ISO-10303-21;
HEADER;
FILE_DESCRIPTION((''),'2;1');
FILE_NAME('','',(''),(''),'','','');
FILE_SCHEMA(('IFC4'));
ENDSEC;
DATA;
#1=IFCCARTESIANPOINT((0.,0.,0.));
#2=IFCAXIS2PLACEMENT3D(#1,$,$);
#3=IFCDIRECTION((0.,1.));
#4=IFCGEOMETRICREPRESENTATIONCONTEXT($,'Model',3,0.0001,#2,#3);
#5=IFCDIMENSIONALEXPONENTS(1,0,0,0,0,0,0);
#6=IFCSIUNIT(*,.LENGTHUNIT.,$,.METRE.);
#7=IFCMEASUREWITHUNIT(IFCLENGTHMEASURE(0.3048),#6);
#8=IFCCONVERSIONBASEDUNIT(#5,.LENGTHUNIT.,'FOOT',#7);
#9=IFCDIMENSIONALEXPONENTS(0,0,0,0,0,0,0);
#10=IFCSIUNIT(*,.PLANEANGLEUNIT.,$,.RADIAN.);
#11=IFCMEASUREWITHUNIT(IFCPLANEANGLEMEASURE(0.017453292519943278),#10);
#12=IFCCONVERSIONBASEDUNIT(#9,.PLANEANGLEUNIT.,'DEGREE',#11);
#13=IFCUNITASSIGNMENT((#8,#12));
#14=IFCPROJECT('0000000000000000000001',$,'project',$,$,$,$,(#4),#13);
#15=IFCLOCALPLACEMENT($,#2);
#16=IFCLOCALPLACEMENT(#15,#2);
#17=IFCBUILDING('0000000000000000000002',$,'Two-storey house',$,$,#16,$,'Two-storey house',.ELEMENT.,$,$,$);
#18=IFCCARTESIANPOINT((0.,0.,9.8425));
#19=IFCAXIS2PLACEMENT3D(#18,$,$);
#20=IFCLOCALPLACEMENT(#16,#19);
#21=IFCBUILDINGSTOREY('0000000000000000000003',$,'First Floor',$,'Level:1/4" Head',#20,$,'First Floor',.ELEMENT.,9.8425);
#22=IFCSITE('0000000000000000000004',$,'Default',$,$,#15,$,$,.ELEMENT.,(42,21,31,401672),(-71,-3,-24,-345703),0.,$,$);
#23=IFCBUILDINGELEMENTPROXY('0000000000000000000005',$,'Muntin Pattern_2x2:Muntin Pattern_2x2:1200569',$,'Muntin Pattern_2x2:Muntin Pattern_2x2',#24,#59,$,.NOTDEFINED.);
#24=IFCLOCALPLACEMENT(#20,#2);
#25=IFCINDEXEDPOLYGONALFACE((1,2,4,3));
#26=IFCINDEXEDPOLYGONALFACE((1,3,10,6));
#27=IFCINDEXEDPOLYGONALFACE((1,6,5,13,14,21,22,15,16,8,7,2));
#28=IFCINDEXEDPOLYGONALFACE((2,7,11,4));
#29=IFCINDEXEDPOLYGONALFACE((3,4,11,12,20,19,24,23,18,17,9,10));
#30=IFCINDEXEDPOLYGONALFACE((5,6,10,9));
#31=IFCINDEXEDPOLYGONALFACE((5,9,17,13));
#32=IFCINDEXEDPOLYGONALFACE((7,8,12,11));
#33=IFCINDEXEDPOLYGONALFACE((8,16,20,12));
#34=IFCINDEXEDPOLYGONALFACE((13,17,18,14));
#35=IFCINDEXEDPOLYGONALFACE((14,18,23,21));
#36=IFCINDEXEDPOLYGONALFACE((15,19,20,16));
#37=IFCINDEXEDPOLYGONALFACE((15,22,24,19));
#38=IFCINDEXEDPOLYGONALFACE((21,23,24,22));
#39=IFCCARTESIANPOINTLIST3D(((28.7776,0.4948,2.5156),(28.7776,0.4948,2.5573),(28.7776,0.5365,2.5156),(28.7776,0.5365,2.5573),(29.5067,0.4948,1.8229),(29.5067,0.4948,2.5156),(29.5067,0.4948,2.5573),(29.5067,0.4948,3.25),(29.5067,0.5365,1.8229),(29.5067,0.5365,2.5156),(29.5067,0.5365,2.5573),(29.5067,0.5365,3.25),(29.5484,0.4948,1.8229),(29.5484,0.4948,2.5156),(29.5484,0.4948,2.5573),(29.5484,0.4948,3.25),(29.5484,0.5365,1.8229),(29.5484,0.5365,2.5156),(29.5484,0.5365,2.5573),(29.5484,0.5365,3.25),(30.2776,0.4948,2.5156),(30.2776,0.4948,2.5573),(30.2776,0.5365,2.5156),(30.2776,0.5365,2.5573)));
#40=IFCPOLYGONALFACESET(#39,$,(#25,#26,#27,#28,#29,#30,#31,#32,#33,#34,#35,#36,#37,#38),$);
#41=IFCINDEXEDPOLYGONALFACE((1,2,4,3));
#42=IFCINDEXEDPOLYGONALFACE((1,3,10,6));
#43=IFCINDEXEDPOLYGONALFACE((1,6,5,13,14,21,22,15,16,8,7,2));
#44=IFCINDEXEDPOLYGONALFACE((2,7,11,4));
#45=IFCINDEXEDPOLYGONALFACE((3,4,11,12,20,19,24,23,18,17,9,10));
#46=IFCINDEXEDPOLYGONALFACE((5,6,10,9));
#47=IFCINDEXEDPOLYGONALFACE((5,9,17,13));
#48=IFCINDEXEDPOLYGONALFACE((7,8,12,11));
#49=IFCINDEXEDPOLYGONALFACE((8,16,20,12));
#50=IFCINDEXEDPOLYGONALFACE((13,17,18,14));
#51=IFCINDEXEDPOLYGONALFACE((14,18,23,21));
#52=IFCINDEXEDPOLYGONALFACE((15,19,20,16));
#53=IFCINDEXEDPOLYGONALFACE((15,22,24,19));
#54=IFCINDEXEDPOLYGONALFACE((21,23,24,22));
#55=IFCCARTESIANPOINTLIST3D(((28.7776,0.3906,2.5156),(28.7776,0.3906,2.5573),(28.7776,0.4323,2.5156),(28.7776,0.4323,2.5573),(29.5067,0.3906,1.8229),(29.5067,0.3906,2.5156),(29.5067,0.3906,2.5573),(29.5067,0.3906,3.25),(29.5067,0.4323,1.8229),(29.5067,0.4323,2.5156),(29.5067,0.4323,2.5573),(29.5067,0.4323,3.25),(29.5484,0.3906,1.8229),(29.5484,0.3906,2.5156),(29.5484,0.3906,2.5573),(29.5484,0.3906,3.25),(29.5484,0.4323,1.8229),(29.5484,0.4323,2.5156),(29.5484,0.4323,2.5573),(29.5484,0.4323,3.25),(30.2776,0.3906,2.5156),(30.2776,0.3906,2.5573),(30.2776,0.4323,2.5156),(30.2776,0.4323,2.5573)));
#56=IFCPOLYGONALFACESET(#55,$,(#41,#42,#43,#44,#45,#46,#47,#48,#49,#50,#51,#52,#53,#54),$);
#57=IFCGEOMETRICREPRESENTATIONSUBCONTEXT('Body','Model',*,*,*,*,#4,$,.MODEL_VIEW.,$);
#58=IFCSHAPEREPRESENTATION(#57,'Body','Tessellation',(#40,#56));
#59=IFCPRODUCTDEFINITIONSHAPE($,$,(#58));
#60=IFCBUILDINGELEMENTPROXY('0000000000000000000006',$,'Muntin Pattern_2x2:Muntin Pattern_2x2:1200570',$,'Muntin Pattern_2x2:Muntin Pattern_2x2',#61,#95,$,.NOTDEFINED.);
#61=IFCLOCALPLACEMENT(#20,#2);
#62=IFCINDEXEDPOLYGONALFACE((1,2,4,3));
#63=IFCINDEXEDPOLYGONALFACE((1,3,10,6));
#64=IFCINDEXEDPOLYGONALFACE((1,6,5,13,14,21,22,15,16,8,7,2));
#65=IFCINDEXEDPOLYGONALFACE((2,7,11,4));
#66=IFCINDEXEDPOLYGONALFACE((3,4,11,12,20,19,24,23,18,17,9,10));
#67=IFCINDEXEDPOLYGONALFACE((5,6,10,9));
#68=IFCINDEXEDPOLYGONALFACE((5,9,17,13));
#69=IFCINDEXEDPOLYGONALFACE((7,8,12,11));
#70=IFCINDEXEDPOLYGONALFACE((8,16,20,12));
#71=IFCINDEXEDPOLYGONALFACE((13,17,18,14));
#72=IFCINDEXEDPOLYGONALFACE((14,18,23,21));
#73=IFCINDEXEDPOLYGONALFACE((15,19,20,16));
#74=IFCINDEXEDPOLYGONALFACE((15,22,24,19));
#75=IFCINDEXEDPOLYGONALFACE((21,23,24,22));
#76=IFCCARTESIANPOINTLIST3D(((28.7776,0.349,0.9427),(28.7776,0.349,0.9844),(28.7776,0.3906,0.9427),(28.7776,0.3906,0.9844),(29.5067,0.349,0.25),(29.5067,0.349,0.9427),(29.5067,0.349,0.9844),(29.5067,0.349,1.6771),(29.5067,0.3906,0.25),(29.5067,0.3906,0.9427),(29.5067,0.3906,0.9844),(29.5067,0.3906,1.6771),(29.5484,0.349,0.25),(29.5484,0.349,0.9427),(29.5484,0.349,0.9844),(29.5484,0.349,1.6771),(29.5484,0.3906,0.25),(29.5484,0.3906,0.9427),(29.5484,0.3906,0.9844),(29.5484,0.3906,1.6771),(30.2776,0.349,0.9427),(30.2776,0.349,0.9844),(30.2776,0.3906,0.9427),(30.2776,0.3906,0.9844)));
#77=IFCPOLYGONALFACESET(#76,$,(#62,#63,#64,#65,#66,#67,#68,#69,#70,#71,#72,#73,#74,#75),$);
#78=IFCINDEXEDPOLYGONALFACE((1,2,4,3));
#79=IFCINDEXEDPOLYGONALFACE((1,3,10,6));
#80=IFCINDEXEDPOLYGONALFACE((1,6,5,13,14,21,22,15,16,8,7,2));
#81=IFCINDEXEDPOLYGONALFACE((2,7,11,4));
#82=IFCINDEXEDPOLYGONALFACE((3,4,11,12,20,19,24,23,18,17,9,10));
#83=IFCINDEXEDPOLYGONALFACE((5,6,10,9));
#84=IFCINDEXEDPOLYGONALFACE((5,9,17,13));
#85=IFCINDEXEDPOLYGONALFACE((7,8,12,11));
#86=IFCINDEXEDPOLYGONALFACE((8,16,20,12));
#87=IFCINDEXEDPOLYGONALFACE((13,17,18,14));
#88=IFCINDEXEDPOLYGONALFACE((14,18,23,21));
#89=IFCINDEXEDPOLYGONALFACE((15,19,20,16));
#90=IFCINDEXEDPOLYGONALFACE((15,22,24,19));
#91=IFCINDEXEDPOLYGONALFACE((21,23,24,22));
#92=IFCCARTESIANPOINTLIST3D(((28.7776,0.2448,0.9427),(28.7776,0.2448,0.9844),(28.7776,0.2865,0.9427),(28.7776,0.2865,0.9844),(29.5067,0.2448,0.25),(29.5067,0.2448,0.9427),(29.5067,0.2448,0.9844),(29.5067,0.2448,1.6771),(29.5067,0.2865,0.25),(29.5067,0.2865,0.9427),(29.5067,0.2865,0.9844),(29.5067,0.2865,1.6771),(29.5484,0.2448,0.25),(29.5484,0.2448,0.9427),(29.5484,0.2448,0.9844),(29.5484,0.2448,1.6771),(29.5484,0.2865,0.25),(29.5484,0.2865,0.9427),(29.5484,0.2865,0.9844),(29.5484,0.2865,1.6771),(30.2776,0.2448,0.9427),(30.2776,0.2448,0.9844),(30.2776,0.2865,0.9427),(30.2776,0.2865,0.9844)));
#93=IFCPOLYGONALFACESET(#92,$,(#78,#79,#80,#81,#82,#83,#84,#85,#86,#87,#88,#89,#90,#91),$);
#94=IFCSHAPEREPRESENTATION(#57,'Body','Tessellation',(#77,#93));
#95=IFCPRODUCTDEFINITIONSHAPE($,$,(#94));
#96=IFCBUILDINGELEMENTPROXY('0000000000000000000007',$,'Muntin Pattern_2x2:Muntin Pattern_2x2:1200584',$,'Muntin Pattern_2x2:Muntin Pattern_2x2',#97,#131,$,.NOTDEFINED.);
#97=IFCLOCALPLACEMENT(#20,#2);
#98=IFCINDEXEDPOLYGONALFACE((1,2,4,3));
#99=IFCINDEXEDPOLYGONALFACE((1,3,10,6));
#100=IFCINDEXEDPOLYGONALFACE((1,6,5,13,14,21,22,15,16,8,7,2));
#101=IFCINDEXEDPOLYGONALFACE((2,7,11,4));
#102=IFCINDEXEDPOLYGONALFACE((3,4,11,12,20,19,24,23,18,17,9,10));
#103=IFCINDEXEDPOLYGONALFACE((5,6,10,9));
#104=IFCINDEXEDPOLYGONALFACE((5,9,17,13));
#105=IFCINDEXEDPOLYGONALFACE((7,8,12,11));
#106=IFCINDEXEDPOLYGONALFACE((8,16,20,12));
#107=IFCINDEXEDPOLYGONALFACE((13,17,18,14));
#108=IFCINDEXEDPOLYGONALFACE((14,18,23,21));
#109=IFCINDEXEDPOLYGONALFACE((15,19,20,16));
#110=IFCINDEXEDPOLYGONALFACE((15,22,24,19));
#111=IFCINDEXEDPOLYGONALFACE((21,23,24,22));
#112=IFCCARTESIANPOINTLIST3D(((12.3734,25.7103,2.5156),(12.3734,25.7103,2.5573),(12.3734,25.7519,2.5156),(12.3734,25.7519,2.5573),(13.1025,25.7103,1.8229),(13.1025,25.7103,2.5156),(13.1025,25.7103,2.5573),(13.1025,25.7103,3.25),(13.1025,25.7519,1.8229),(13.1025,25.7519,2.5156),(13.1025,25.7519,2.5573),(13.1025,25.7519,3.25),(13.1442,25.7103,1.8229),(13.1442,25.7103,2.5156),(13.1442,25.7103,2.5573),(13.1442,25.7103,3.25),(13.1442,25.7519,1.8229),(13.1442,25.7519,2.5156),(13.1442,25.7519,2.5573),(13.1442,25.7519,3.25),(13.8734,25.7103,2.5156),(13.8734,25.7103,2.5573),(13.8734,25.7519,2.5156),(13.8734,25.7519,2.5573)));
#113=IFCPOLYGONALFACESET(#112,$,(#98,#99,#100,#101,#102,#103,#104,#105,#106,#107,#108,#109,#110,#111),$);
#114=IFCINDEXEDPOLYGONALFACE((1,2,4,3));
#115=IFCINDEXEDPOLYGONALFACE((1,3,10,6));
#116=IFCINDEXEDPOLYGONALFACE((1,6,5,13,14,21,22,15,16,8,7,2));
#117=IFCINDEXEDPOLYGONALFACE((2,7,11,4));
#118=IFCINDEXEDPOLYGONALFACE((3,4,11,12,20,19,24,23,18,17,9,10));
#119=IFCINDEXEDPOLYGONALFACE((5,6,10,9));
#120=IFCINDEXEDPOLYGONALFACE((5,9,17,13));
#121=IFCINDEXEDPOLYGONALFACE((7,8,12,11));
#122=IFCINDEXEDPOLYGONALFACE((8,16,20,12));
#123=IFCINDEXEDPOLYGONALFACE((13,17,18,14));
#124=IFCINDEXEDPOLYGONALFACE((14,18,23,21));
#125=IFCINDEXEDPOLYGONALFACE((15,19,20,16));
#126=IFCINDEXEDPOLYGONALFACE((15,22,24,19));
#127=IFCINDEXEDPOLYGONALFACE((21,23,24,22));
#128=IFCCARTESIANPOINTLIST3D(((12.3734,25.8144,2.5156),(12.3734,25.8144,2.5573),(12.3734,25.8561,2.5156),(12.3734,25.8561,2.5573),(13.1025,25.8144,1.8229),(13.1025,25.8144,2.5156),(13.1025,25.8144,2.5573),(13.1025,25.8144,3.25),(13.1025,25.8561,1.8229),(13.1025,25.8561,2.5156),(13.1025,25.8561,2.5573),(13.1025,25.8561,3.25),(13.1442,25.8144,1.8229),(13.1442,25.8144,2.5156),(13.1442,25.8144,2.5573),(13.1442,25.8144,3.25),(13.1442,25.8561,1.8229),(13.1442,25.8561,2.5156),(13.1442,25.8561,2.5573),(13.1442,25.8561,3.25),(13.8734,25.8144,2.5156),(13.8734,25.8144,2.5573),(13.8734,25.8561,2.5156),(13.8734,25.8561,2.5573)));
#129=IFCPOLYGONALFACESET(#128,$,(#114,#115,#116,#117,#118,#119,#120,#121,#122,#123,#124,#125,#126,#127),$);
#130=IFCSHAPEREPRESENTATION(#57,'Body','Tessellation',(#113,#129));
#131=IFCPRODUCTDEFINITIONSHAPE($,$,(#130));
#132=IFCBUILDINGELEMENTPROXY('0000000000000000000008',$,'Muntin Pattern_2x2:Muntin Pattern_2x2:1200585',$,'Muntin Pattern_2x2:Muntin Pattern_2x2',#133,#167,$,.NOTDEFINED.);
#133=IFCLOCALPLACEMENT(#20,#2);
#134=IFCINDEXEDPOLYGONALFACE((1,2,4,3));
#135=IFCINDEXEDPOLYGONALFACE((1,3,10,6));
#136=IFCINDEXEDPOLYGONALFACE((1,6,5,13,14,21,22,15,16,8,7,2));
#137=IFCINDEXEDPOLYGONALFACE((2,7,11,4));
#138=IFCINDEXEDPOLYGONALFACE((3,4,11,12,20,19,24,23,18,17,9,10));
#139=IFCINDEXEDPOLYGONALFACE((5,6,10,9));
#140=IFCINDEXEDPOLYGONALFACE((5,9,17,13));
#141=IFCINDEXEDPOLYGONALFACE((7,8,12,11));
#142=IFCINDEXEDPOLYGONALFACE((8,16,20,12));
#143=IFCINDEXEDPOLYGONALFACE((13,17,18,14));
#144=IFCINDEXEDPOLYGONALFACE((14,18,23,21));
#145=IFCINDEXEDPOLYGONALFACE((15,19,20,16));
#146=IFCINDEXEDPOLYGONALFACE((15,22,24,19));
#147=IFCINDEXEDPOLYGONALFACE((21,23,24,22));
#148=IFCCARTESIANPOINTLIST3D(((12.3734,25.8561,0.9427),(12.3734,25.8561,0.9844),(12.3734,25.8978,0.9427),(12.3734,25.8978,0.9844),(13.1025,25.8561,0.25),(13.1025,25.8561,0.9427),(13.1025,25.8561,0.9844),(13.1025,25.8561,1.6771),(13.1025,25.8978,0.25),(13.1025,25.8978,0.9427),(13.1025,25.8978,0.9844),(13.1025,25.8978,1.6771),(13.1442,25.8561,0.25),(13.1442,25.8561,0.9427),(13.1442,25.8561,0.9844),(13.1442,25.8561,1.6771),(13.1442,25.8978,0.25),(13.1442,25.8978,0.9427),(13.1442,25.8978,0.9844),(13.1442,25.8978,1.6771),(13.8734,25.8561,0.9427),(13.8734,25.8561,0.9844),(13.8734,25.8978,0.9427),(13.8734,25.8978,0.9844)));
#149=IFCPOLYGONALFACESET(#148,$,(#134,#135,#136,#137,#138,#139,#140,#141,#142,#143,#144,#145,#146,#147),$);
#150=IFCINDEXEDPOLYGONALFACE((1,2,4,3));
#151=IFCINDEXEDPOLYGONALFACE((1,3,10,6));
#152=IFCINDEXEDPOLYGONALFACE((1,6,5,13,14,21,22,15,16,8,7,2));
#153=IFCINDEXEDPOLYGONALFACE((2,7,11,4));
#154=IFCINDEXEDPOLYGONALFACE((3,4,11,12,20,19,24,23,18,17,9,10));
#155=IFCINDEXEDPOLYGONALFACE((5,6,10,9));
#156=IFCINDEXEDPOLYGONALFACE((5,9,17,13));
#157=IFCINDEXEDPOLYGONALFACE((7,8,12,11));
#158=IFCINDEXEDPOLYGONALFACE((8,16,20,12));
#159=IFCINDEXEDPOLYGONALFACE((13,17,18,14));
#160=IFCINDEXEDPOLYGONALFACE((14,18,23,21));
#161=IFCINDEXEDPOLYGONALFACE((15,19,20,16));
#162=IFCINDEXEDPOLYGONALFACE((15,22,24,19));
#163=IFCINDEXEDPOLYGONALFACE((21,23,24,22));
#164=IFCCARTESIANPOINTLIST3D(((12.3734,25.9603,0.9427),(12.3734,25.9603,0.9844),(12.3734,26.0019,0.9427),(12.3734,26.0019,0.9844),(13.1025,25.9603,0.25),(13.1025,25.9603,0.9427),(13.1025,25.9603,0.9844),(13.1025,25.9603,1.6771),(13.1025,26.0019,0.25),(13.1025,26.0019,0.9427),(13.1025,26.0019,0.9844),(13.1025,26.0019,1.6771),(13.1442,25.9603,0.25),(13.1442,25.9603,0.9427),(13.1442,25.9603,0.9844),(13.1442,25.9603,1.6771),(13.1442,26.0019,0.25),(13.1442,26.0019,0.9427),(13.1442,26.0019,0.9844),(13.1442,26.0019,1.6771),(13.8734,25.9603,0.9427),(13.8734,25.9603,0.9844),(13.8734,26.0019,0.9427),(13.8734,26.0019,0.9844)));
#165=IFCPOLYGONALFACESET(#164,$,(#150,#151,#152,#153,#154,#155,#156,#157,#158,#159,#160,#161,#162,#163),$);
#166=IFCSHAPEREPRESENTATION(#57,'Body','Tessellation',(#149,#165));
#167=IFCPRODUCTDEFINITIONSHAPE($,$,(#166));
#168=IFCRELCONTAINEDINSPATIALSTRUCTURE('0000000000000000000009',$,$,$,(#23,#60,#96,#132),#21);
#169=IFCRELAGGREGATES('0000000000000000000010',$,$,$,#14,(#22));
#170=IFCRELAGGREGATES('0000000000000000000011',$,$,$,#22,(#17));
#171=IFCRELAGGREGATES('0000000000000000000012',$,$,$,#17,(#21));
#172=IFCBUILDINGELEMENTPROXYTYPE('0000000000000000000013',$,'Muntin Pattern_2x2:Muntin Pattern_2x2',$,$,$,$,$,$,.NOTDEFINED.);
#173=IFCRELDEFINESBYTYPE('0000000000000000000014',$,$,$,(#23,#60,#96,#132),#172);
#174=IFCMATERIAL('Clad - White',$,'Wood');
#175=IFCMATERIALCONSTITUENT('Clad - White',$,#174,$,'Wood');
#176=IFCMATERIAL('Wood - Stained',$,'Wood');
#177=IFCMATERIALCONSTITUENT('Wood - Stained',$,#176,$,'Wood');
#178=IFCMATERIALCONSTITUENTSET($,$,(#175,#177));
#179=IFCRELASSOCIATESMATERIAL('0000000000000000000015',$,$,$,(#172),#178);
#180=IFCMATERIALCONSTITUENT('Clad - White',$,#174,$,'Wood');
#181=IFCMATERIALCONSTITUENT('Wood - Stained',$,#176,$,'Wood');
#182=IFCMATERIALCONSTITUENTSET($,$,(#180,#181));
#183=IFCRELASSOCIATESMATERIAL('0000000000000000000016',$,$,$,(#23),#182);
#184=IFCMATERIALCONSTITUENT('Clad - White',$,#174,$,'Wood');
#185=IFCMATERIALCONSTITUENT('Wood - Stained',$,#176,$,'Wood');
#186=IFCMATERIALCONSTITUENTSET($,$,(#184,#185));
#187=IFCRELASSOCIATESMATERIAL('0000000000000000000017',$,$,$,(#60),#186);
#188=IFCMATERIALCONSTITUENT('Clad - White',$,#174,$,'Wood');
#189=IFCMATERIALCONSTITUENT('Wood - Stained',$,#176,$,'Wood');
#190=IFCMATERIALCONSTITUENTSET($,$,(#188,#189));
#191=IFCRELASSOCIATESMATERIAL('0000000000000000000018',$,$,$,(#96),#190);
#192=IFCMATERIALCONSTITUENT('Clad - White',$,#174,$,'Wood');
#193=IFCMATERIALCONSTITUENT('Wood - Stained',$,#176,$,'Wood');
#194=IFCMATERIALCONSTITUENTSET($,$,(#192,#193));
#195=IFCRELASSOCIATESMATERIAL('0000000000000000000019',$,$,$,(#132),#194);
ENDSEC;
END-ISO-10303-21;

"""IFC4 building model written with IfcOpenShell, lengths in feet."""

from ifc_helpers import new_model, entity, si_unit, converted_unit, direction, frame, origin, place, context, subcontext, project, spatial, indexed_curve, outline, extrude, source, transform, mapped, material, constituent, constituent_set, type_object, type_shapes, element, save


model = new_model("IFC4")

# Units and contexts
model_context = context("Model", 3, precision=0.0001, world=origin(), true_north=direction((0.0, 1.0)))
body_context = subcontext(model_context, "Body", "Model", "MODEL_VIEW")
ifc_project = project(units=[converted_unit("LENGTHUNIT", "FOOT", entity("IfcLengthMeasure", 0.3048), si_unit("LENGTHUNIT", "METRE"), dimensions=[1, 0, 0, 0, 0, 0, 0]), converted_unit("PLANEANGLEUNIT", "DEGREE", entity("IfcPlaneAngleMeasure", 0.017453292519943278), si_unit("PLANEANGLEUNIT", "RADIAN"), dimensions=[0, 0, 0, 0, 0, 0, 0])], contexts=[model_context])

# Site, building, storey
site_placement = place(None, origin())
site = spatial("IfcSite", under=ifc_project, at=site_placement, Name="Default", CompositionType="ELEMENT", RefLatitude=(42, 21, 31, 401672), RefLongitude=(-71, -3, -24, -345703), RefElevation=0.0)
building_placement = place(site_placement, origin())
building = spatial("IfcBuilding", under=site, at=building_placement, Name="Two-storey house", LongName="Two-storey house", CompositionType="ELEMENT")
storey_placement = place(building_placement, frame((0.0, 0.0, 9.8425)))
storey = spatial("IfcBuildingStorey", under=building, at=storey_placement, Name="First Floor", ObjectType="Level:1/4\" Head", LongName="First Floor", CompositionType="ELEMENT", Elevation=9.8425)

# Shared definitions
ifc_material_1 = material(Name="Wood - Stained", Category="Wood")

# Building element proxies
ifc_material_2 = material(Name="Clad - White", Category="Wood")
ifc_constituent_1 = constituent(ifc_material_2, Name="Clad - White", Category="Wood")
ifc_constituent_2 = constituent(ifc_material_1, Name="Wood - Stained", Category="Wood")
ifc_constituent_set_1 = constituent_set(constituents=[ifc_constituent_1, ifc_constituent_2])
ifc_constituent_3 = constituent(ifc_material_2, Name="Clad - White", Category="Wood")
ifc_constituent_4 = constituent(ifc_material_1, Name="Wood - Stained", Category="Wood")
ifc_constituent_set_2 = constituent_set(constituents=[ifc_constituent_3, ifc_constituent_4])
building_element_proxy_type_1 = type_object("IfcBuildingElementProxyType", Name="Muntin Pattern_2x2:Muntin Pattern_2x2", PredefinedType="NOTDEFINED", material=ifc_constituent_set_2)
shared_shape_1 = source(origin(), body_context, "Body", "SweptSolid", [
    extrude(outline(indexed_curve([(0.0208, -0.0208), (0.7135, -0.0208), (0.7135, 0.0208), (0.0208, 0.0208), (0.0208, 0.75), (-0.0208, 0.75), (-0.0208, 0.0208), (-0.7135, 0.0208), (-0.7135, -0.0208), (-0.0208, -0.0208), (-0.0208, -0.75), (0.0208, -0.75), (0.0208, -0.0208)], self_intersect=False)), frame((0.0, 0.0312, 0.7135), z_axis=(0.0, 1.0, 0.0), x_axis=(0.0, 0.0, 1.0)), (0.0, 0.0, 1.0), 0.0417),
    extrude(outline(indexed_curve([(0.0208, -0.0208), (0.7135, -0.0208), (0.7135, 0.0208), (0.0208, 0.0208), (0.0208, 0.75), (-0.0208, 0.75), (-0.0208, 0.0208), (-0.7135, 0.0208), (-0.7135, -0.0208), (-0.0208, -0.0208), (-0.0208, -0.75), (0.0208, -0.75), (0.0208, -0.0208)], self_intersect=False)), frame((0.0, -0.0729, 0.7135), z_axis=(0.0, 1.0, 0.0), x_axis=(0.0, 0.0, 1.0)), (0.0, 0.0, 1.0), 0.0417),
])
type_shapes(building_element_proxy_type_1, [shared_shape_1])
proxy_1_placement = place(storey_placement, frame((29.5276, 0.4635, 1.8229)))
element("IfcBuildingElementProxy", 1, at=proxy_1_placement, inside=storey, type_object=building_element_proxy_type_1, material=ifc_constituent_set_1, Name="Muntin Pattern_2x2:Muntin Pattern_2x2:1200569", ObjectType="Muntin Pattern_2x2:Muntin Pattern_2x2", PredefinedType="NOTDEFINED", context=body_context, shape_type="MappedRepresentation", body=[
    mapped(shared_shape_1, transform((0.0, 0.0, 0.0), scale=1.0)),
])
ifc_constituent_5 = constituent(ifc_material_2, Name="Clad - White", Category="Wood")
ifc_constituent_6 = constituent(ifc_material_1, Name="Wood - Stained", Category="Wood")
ifc_constituent_set_3 = constituent_set(constituents=[ifc_constituent_5, ifc_constituent_6])
proxy_2_placement = place(storey_placement, frame((29.5276, 0.3177, 0.25)))
element("IfcBuildingElementProxy", 2, at=proxy_2_placement, inside=storey, type_object=building_element_proxy_type_1, material=ifc_constituent_set_3, Name="Muntin Pattern_2x2:Muntin Pattern_2x2:1200570", ObjectType="Muntin Pattern_2x2:Muntin Pattern_2x2", PredefinedType="NOTDEFINED", context=body_context, shape_type="MappedRepresentation", body=[
    mapped(shared_shape_1, transform((0.0, 0.0, 0.0), scale=1.0)),
])
ifc_constituent_7 = constituent(ifc_material_2, Name="Clad - White", Category="Wood")
ifc_constituent_8 = constituent(ifc_material_1, Name="Wood - Stained", Category="Wood")
ifc_constituent_set_4 = constituent_set(constituents=[ifc_constituent_7, ifc_constituent_8])
proxy_3_placement = place(storey_placement, frame((13.1234, 25.7832, 1.8229), z_axis=(0.0, 0.0, 1.0), x_axis=(-1.0, 0.0, 0.0)))
element("IfcBuildingElementProxy", 3, at=proxy_3_placement, inside=storey, type_object=building_element_proxy_type_1, material=ifc_constituent_set_4, Name="Muntin Pattern_2x2:Muntin Pattern_2x2:1200584", ObjectType="Muntin Pattern_2x2:Muntin Pattern_2x2", PredefinedType="NOTDEFINED", context=body_context, shape_type="MappedRepresentation", body=[
    mapped(shared_shape_1, transform((0.0, 0.0, 0.0), scale=1.0)),
])
ifc_constituent_9 = constituent(ifc_material_2, Name="Clad - White", Category="Wood")
ifc_constituent_10 = constituent(ifc_material_1, Name="Wood - Stained", Category="Wood")
ifc_constituent_set_5 = constituent_set(constituents=[ifc_constituent_9, ifc_constituent_10])
proxy_4_placement = place(storey_placement, frame((13.1234, 25.929, 0.25), z_axis=(0.0, 0.0, 1.0), x_axis=(-1.0, 0.0, 0.0)))
element("IfcBuildingElementProxy", 4, at=proxy_4_placement, inside=storey, type_object=building_element_proxy_type_1, material=ifc_constituent_set_5, Name="Muntin Pattern_2x2:Muntin Pattern_2x2:1200585", ObjectType="Muntin Pattern_2x2:Muntin Pattern_2x2", PredefinedType="NOTDEFINED", context=body_context, shape_type="MappedRepresentation", body=[
    mapped(shared_shape_1, transform((0.0, 0.0, 0.0), scale=1.0)),
])

save(model, "model.ifc")
